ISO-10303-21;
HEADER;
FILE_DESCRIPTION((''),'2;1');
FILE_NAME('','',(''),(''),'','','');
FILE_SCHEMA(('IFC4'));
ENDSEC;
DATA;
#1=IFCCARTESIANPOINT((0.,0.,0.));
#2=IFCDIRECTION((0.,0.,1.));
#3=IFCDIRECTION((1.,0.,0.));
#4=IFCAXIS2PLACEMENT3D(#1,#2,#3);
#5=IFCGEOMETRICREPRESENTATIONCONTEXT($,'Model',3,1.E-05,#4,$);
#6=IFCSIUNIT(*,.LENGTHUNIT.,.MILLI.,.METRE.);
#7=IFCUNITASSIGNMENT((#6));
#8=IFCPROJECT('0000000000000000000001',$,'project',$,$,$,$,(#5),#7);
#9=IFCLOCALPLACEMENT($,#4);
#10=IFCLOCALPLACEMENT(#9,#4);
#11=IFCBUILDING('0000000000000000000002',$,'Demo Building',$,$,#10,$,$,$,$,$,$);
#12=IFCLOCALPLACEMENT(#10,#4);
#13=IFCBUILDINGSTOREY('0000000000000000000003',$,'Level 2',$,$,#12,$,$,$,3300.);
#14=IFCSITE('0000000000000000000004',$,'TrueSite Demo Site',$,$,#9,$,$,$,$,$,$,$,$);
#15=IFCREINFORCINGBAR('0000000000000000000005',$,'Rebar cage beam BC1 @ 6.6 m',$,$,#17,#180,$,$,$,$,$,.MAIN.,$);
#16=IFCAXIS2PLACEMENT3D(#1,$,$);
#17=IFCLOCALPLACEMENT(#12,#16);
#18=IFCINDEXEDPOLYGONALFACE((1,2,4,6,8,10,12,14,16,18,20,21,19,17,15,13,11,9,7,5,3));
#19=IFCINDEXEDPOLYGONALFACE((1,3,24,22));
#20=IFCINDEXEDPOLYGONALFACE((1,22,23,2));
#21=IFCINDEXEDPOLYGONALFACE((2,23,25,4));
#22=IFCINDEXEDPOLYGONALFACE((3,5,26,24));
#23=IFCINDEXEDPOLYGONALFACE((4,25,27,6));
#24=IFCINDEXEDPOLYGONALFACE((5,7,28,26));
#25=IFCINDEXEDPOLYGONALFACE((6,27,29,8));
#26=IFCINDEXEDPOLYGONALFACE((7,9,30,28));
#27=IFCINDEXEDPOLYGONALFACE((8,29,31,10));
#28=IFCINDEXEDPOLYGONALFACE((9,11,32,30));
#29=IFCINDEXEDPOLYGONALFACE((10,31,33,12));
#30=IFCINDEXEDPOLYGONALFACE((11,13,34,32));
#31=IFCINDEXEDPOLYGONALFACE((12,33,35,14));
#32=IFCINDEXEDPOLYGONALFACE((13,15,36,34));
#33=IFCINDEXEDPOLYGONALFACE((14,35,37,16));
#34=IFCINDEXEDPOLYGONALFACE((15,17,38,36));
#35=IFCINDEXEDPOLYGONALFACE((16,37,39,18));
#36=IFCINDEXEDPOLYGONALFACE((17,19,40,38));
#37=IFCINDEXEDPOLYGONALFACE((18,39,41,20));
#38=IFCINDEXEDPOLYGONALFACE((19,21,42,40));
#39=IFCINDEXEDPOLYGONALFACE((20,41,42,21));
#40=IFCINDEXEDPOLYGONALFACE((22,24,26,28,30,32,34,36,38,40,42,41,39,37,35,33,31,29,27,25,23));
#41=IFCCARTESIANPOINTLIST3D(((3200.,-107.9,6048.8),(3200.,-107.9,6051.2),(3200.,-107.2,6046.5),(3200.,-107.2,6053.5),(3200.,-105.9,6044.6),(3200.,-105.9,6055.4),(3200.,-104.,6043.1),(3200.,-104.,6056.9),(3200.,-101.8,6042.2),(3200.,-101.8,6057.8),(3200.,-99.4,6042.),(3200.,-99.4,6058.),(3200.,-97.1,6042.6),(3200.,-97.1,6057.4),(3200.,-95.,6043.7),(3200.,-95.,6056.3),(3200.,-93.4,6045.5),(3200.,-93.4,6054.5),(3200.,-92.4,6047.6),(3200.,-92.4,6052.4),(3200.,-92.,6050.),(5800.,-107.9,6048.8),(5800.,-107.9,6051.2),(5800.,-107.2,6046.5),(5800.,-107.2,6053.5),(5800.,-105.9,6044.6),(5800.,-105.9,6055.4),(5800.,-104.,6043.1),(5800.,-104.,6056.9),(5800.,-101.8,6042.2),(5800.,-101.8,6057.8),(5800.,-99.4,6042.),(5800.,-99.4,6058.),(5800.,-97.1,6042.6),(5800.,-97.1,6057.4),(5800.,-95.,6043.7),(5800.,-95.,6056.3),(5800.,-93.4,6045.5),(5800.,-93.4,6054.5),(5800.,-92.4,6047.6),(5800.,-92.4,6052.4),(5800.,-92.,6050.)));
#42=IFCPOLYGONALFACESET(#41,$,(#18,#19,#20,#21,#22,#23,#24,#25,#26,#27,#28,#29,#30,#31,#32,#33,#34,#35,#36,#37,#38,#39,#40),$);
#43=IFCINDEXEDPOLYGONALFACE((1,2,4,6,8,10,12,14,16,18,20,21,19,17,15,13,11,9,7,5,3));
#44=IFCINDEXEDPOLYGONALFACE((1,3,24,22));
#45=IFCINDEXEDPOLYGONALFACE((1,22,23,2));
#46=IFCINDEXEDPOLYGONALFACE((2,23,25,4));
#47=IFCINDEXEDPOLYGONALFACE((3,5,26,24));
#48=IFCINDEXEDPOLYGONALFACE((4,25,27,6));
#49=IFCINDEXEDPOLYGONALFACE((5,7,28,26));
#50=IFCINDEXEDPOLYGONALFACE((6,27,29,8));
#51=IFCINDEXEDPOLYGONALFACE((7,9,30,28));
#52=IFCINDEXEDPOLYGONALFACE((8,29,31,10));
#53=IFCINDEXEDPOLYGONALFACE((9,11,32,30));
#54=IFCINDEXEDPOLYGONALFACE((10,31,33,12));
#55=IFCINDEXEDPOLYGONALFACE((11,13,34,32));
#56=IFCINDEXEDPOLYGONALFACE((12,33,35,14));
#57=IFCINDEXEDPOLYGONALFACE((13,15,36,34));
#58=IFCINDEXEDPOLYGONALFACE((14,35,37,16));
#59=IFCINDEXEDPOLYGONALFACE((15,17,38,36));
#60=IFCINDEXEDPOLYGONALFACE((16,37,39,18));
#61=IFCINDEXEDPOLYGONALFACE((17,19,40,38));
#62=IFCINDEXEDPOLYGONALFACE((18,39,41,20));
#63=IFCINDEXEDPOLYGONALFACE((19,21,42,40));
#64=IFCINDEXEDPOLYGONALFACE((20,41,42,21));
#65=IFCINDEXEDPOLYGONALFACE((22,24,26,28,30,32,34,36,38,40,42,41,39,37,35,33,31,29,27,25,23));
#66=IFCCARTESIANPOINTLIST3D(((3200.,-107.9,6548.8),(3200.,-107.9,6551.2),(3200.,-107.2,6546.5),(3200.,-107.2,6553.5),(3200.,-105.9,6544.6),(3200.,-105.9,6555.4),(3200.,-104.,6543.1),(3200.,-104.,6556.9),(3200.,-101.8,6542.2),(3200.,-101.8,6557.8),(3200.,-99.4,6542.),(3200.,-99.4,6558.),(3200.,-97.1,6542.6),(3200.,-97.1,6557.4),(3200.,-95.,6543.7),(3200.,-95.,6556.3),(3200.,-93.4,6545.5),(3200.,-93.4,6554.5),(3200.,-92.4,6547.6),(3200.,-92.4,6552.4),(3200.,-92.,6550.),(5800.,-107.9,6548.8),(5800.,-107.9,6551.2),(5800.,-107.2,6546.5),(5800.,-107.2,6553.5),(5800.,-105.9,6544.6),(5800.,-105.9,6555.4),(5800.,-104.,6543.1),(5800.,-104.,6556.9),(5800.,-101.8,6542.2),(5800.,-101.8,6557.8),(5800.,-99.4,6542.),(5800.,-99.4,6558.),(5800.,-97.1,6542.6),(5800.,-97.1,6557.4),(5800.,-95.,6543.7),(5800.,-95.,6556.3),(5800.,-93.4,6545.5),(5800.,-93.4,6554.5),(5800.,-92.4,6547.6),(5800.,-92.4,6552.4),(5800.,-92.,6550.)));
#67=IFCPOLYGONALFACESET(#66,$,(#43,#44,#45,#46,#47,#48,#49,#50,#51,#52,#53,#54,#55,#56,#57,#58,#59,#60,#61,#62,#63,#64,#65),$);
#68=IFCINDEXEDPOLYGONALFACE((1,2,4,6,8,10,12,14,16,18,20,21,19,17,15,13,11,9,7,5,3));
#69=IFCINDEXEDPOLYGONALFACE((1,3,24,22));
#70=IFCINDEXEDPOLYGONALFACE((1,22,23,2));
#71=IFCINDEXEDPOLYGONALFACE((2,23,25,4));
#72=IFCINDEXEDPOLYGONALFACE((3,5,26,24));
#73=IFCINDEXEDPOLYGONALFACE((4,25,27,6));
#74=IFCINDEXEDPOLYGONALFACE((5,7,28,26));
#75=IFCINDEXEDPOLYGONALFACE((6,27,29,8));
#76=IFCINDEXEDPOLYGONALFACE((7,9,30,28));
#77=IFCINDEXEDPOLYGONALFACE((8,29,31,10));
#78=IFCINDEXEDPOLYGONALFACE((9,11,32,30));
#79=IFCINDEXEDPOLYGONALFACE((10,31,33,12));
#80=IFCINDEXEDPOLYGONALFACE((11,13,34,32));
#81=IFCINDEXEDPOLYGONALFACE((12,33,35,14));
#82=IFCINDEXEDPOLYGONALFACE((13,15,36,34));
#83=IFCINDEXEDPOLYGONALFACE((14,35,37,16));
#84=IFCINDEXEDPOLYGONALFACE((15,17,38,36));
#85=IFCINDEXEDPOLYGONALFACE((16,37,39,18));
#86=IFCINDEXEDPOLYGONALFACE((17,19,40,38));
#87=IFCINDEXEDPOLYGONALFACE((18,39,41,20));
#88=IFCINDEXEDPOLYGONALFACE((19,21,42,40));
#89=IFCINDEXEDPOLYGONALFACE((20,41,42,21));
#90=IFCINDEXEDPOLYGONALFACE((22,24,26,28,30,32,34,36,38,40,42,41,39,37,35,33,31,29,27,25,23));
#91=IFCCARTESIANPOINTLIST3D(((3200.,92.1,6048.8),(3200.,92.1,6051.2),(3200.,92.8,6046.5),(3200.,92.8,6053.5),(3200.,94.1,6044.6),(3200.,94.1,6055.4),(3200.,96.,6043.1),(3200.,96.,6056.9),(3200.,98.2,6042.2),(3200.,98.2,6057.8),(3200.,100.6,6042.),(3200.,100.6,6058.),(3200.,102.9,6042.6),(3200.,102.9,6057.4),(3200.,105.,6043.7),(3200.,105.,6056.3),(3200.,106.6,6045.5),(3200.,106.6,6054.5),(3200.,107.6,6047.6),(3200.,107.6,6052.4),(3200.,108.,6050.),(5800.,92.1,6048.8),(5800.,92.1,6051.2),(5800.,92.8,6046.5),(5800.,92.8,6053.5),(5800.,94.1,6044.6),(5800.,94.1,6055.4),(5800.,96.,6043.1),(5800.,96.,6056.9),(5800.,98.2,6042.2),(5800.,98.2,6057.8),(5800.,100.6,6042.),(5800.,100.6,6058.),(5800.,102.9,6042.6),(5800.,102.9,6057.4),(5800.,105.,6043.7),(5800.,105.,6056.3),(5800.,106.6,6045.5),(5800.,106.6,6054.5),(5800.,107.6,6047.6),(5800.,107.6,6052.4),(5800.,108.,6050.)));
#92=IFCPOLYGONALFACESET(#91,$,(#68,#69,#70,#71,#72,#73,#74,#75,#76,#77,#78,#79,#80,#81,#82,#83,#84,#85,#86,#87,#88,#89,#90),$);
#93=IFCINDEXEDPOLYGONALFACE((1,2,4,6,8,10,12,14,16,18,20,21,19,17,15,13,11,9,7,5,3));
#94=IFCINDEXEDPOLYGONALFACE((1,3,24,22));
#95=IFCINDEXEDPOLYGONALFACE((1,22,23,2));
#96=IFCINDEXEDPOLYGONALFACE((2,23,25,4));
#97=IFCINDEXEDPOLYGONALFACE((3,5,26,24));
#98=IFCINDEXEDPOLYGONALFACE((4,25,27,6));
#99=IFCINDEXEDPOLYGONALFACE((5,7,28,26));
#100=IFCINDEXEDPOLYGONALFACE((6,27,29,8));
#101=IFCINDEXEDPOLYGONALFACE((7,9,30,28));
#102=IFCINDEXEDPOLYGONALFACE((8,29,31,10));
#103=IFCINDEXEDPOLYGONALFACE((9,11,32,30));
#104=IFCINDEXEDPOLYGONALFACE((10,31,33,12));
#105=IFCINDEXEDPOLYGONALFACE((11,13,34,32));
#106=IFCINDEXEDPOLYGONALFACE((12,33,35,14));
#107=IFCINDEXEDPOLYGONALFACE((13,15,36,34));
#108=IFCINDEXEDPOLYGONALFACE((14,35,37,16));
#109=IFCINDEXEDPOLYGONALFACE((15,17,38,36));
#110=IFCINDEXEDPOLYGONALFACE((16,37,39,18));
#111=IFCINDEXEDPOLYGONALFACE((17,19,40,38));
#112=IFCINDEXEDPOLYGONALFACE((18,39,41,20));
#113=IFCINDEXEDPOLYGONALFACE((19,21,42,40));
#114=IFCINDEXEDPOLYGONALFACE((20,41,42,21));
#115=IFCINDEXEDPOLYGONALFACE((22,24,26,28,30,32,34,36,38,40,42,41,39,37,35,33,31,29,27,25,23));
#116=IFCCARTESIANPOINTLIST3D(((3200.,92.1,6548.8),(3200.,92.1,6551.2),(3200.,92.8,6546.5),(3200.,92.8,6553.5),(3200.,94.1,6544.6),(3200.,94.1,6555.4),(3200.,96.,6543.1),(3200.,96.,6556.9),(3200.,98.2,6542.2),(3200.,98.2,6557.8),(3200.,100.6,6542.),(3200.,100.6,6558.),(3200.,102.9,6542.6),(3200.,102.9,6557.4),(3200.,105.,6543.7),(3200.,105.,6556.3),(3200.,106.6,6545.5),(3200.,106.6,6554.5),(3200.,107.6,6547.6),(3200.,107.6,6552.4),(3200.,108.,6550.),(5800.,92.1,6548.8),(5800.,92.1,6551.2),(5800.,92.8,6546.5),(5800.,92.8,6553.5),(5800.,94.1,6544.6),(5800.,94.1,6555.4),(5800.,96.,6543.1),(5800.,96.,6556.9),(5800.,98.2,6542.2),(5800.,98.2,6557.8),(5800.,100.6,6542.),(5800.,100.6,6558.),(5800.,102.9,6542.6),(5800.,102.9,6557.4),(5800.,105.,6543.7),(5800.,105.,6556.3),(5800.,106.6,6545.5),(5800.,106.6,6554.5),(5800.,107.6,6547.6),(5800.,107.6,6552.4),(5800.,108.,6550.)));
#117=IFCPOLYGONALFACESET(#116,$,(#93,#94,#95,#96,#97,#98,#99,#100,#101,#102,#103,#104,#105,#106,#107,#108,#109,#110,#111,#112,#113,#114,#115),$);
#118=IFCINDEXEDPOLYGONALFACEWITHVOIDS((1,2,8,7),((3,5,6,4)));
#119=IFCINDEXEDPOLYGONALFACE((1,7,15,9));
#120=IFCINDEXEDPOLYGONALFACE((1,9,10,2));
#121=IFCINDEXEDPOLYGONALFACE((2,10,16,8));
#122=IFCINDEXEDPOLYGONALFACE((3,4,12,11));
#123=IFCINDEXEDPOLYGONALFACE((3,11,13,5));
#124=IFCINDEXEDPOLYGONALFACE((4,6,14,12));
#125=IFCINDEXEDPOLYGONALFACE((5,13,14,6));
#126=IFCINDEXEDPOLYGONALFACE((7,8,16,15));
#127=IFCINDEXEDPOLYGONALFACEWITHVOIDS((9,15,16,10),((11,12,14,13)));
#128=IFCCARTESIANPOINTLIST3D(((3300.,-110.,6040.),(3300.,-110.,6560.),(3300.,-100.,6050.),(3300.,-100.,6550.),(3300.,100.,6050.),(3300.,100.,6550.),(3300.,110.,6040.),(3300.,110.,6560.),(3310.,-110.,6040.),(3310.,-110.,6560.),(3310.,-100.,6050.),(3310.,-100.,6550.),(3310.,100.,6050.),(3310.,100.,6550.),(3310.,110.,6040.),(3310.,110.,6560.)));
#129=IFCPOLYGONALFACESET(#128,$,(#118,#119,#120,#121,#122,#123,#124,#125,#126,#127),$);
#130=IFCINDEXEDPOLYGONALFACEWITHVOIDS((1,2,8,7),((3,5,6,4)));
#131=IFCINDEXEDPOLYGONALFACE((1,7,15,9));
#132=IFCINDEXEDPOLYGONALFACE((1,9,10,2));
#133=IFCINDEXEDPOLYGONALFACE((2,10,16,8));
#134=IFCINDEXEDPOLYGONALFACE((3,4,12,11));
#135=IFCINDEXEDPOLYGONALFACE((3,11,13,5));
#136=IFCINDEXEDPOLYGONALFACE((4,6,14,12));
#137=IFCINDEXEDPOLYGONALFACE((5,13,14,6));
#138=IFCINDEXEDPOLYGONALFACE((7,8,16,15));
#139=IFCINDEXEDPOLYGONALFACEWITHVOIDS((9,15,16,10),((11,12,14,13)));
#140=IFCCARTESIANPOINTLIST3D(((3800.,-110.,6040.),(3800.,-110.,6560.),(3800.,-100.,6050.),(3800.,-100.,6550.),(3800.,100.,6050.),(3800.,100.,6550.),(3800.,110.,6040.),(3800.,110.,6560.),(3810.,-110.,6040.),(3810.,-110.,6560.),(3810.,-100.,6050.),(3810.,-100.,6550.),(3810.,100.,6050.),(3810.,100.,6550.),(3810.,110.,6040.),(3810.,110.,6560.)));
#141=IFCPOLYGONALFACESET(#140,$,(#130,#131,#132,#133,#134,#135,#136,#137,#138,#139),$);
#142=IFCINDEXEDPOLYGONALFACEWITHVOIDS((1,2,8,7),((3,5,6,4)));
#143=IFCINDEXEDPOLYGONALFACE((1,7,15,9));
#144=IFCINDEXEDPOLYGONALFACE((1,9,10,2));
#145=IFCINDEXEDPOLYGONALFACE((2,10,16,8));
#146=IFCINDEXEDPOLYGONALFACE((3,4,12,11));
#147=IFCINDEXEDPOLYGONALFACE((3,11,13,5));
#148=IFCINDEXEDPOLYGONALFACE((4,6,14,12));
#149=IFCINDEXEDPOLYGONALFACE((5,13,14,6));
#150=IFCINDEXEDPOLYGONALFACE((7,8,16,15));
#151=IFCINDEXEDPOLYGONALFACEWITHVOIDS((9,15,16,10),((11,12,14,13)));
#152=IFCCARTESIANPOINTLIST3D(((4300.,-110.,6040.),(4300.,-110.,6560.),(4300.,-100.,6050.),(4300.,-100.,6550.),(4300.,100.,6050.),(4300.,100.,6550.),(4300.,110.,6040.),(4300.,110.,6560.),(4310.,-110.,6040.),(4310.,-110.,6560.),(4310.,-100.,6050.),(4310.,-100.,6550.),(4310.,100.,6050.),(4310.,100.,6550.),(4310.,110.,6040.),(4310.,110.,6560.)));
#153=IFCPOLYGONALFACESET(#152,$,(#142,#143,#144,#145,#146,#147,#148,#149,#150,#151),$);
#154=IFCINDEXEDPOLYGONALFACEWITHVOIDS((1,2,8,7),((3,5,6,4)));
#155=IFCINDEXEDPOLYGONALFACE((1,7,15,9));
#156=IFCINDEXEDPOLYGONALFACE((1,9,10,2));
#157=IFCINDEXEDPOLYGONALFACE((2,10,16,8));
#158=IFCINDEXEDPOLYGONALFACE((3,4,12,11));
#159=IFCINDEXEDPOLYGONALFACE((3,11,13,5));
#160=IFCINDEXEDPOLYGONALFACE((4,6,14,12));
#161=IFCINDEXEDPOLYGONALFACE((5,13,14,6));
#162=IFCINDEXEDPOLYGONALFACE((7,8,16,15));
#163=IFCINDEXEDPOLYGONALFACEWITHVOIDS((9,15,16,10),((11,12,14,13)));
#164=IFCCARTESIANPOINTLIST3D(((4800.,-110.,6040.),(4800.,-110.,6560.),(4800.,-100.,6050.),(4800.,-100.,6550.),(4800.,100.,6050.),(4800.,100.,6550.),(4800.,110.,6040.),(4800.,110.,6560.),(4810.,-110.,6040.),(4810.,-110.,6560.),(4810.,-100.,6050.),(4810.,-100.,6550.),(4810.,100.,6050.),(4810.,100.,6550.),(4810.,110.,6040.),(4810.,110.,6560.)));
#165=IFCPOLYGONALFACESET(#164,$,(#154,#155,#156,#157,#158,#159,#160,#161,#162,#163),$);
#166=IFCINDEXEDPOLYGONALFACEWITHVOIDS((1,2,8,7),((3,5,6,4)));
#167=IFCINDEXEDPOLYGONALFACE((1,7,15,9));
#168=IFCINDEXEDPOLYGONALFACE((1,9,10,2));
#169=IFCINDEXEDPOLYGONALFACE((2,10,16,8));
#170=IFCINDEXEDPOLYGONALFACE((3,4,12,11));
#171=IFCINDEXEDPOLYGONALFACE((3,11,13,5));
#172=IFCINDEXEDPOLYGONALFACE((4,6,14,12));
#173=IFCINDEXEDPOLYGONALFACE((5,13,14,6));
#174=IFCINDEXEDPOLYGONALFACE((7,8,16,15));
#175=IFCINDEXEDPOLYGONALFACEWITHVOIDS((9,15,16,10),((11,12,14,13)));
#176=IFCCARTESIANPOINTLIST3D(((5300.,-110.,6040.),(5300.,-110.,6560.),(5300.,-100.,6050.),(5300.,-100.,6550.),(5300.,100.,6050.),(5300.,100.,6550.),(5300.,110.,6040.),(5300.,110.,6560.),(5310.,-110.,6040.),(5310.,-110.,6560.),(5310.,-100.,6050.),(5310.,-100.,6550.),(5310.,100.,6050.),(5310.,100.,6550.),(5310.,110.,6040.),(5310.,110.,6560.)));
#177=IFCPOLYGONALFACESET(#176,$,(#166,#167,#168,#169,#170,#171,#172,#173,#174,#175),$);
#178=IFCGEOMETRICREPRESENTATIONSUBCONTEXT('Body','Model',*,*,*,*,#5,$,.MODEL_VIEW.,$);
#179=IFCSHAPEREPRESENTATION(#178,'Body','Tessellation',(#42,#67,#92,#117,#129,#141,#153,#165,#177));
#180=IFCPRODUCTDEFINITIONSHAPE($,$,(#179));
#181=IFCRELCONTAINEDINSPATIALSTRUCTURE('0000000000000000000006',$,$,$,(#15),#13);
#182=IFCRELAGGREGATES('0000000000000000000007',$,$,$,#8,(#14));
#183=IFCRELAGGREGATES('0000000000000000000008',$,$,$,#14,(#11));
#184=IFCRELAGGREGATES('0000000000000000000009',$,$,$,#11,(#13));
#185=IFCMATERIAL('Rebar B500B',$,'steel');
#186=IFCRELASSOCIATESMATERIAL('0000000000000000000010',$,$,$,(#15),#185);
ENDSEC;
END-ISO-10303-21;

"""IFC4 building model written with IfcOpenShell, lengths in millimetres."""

from ifc_helpers import new_model, si_unit, frame, origin_with_axes, place, context, subcontext, project, spatial, hollow_rectangle, circle, extrude, material, element, save


model = new_model("IFC4")

# Units and contexts
model_context = context("Model", 3, precision=1e-05, world=origin_with_axes())
body_context = subcontext(model_context, "Body", "Model", "MODEL_VIEW")
ifc_project = project(units=[si_unit("LENGTHUNIT", "METRE", prefix="MILLI")], contexts=[model_context])

# Site, building, storey
site_placement = place(None, origin_with_axes())
site = spatial("IfcSite", under=ifc_project, at=site_placement, Name="TrueSite Demo Site")
building_placement = place(site_placement, origin_with_axes())
building = spatial("IfcBuilding", under=site, at=building_placement, Name="Demo Building")
storey_placement = place(building_placement, origin_with_axes())
storey = spatial("IfcBuildingStorey", under=building, at=storey_placement, Name="Level 2", Elevation=3300.0)

# Reinforcing bar
ifc_material_1 = material(Name="Rebar B500B", Category="steel")
for number, where, z_axis, x_axis, name in (
    (1, (3200.0, 0.0, 6300.0), (1.0, 0.0, 0.0), (0.0, 1.0, 0.0), "Rebar cage beam BC1 @ 6.6 m"),
):
    element("IfcReinforcingBar", number, at=place(storey_placement, frame(where, z_axis=z_axis, x_axis=x_axis)), inside=storey, material=ifc_material_1, Name=name, PredefinedType="MAIN", context=body_context, shape_type="SweptSolid", body=[
        extrude(circle(Radius=8.0), frame((-100.0, -250.0, 0.0)), (0.0, 0.0, 1.0), 2600.0),
        extrude(circle(Radius=8.0), frame((-100.0, 250.0, 0.0)), (0.0, 0.0, 1.0), 2600.0),
        extrude(circle(Radius=8.0), frame((100.0, -250.0, 0.0)), (0.0, 0.0, 1.0), 2600.0),
        extrude(circle(Radius=8.0), frame((100.0, 250.0, 0.0)), (0.0, 0.0, 1.0), 2600.0),
        extrude(hollow_rectangle(XDim=220.0, YDim=520.0, WallThickness=10.0), frame((0.0, 0.0, 100.0)), (0.0, 0.0, 1.0), 10.0),
        extrude(hollow_rectangle(XDim=220.0, YDim=520.0, WallThickness=10.0), frame((0.0, 0.0, 600.0)), (0.0, 0.0, 1.0), 10.0),
        extrude(hollow_rectangle(XDim=220.0, YDim=520.0, WallThickness=10.0), frame((0.0, 0.0, 1100.0)), (0.0, 0.0, 1.0), 10.0),
        extrude(hollow_rectangle(XDim=220.0, YDim=520.0, WallThickness=10.0), frame((0.0, 0.0, 1600.0)), (0.0, 0.0, 1.0), 10.0),
        extrude(hollow_rectangle(XDim=220.0, YDim=520.0, WallThickness=10.0), frame((0.0, 0.0, 2100.0)), (0.0, 0.0, 1.0), 10.0),
    ])

save(model, "model.ifc")
